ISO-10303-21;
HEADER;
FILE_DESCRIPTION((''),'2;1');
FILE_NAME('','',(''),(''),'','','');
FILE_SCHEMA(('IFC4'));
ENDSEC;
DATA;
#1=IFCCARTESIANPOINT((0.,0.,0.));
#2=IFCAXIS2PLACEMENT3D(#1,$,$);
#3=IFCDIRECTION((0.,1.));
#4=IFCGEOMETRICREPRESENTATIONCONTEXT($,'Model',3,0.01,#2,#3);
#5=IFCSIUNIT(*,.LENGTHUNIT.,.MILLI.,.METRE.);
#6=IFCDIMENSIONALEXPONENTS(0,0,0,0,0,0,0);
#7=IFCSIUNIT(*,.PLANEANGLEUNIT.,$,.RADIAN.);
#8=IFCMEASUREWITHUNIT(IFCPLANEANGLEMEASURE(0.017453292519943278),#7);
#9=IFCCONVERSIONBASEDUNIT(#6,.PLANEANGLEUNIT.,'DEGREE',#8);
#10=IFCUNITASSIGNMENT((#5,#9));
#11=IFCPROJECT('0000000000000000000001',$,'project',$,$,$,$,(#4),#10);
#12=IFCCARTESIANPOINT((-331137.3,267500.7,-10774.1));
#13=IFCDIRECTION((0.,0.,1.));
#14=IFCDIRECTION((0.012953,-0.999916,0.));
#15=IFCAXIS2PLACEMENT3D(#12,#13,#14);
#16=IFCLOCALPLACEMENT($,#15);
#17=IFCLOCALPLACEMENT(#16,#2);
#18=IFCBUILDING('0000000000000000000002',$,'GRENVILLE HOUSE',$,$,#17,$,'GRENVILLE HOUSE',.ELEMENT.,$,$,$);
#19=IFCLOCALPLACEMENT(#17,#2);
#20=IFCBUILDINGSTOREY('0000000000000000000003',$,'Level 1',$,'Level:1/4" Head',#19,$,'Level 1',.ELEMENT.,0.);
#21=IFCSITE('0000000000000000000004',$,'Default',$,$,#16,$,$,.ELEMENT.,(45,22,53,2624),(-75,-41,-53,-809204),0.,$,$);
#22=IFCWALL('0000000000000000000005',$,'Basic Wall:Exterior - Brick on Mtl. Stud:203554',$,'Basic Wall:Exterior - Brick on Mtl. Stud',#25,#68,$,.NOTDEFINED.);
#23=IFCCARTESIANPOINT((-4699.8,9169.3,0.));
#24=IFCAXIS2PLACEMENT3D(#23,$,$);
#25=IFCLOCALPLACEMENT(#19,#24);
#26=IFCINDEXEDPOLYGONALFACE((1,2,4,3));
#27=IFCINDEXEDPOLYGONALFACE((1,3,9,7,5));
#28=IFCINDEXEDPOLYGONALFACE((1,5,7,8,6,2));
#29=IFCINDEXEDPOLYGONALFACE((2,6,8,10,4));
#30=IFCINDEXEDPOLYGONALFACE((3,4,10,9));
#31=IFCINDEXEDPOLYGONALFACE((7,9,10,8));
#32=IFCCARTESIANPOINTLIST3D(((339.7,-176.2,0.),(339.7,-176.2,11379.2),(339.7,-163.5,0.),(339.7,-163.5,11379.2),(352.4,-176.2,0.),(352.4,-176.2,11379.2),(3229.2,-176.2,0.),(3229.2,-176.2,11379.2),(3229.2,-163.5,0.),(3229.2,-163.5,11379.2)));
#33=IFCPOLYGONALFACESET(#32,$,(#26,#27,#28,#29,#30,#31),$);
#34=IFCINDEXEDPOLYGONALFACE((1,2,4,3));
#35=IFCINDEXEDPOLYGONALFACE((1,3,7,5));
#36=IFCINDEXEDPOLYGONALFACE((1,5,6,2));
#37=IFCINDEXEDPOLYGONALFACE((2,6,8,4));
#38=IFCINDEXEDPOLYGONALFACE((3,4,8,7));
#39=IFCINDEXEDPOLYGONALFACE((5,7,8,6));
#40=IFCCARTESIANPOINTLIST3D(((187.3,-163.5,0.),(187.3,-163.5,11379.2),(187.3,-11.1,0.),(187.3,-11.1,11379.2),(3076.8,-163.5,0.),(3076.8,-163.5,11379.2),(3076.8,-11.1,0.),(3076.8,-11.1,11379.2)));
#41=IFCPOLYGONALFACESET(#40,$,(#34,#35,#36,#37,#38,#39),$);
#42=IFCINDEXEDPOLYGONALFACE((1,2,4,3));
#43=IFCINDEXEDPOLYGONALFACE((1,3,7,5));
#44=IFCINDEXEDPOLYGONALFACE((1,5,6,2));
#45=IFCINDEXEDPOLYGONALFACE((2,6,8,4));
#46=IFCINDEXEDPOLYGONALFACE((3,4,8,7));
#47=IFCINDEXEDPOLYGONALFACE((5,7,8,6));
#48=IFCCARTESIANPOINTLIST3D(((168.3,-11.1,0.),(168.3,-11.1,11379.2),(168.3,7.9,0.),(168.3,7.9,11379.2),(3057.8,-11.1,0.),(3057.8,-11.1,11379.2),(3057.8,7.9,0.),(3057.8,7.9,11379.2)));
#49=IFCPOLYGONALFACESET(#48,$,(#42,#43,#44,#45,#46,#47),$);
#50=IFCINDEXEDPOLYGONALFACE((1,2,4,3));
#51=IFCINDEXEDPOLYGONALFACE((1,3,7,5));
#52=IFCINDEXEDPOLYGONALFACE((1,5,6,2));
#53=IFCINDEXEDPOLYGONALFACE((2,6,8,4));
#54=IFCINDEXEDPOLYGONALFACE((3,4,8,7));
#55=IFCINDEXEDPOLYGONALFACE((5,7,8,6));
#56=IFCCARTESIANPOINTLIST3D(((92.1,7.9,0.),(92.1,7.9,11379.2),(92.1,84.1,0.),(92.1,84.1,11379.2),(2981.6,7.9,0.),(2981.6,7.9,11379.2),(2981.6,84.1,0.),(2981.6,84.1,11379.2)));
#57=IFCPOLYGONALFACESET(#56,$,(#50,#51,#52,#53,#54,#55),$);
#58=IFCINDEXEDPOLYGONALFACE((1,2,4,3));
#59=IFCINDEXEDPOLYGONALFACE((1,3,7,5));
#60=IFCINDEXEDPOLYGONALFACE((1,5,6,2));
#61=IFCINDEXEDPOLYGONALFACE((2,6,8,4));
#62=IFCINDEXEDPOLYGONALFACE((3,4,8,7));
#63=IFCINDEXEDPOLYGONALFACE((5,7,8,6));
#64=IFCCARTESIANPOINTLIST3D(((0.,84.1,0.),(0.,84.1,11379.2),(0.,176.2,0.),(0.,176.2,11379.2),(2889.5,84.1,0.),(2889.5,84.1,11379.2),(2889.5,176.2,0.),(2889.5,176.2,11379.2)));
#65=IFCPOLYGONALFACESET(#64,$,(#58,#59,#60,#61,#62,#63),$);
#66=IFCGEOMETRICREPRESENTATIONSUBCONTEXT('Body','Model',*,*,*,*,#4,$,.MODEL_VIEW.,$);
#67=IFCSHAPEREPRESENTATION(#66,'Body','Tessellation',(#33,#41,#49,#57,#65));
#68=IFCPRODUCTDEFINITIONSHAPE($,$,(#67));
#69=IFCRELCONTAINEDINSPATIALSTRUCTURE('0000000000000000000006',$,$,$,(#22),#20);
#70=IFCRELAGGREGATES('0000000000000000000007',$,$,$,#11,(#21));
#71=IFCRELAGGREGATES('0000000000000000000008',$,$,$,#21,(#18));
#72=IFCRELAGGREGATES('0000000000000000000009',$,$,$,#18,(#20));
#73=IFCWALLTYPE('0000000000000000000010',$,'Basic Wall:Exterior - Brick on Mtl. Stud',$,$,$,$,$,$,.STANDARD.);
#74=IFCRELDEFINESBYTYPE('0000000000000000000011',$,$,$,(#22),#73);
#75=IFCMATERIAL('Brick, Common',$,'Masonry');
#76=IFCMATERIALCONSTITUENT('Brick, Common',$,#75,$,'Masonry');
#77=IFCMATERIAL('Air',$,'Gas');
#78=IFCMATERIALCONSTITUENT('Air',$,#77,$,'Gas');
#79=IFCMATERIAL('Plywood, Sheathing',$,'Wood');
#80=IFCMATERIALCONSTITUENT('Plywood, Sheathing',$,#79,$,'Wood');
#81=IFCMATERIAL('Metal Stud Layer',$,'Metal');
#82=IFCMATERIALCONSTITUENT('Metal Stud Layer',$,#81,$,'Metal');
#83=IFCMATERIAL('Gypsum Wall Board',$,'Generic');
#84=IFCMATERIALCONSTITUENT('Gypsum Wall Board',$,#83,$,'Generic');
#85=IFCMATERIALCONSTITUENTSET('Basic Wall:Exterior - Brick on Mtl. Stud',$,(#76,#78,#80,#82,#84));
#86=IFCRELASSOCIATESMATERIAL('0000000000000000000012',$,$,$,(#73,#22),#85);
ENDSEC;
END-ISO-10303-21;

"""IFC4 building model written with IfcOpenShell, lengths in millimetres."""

from ifc_helpers import new_model, entity, si_unit, converted_unit, direction, frame, origin, place, context, subcontext, project, spatial, indexed_curve, outline, extrude, material, constituent, constituent_set, type_object, element, save


model = new_model("IFC4")

# Units and contexts
model_context = context("Model", 3, precision=0.01, world=origin(), true_north=direction((0.0, 1.0)))
body_context = subcontext(model_context, "Body", "Model", "MODEL_VIEW")
ifc_project = project(units=[si_unit("LENGTHUNIT", "METRE", prefix="MILLI"), converted_unit("PLANEANGLEUNIT", "DEGREE", entity("IfcPlaneAngleMeasure", 0.017453292519943278), si_unit("PLANEANGLEUNIT", "RADIAN"), dimensions=[0, 0, 0, 0, 0, 0, 0])], contexts=[model_context])

# Site, building, storey
site_placement = place(None, frame((-331137.3, 267500.7, -10774.1), z_axis=(0.0, 0.0, 1.0), x_axis=(0.012953, -0.999916, 0.0)))
site = spatial("IfcSite", under=ifc_project, at=site_placement, Name="Default", CompositionType="ELEMENT", RefLatitude=(45, 22, 53, 2624), RefLongitude=(-75, -41, -53, -809204), RefElevation=0.0)
building_placement = place(site_placement, origin())
building = spatial("IfcBuilding", under=site, at=building_placement, Name="GRENVILLE HOUSE", LongName="GRENVILLE HOUSE", CompositionType="ELEMENT")
storey_placement = place(building_placement, origin())
storey = spatial("IfcBuildingStorey", under=building, at=storey_placement, Name="Level 1", ObjectType="Level:1/4\" Head", LongName="Level 1", CompositionType="ELEMENT", Elevation=0.0)

# Wall
ifc_material_1 = material(Name="Brick, Common", Category="Masonry")
ifc_constituent_1 = constituent(ifc_material_1, Name="Brick, Common", Category="Masonry")
ifc_material_2 = material(Name="Air", Category="Gas")
ifc_constituent_2 = constituent(ifc_material_2, Name="Air", Category="Gas")
ifc_material_3 = material(Name="Plywood, Sheathing", Category="Wood")
ifc_constituent_3 = constituent(ifc_material_3, Name="Plywood, Sheathing", Category="Wood")
ifc_material_4 = material(Name="Metal Stud Layer", Category="Metal")
ifc_constituent_4 = constituent(ifc_material_4, Name="Metal Stud Layer", Category="Metal")
ifc_material_5 = material(Name="Gypsum Wall Board", Category="Generic")
ifc_constituent_5 = constituent(ifc_material_5, Name="Gypsum Wall Board", Category="Generic")
ifc_constituent_set_1 = constituent_set(constituents=[ifc_constituent_1, ifc_constituent_2, ifc_constituent_3, ifc_constituent_4, ifc_constituent_5], Name="Basic Wall:Exterior - Brick on Mtl. Stud")
wall_type_1 = type_object("IfcWallType", Name="Basic Wall:Exterior - Brick on Mtl. Stud", PredefinedType="STANDARD", material=ifc_constituent_set_1)
wall_1_placement = place(storey_placement, frame((-4699.8, 9169.3, 0.0)))
element("IfcWall", 1, at=wall_1_placement, inside=storey, type_object=wall_type_1, material=ifc_constituent_set_1, Name="Basic Wall:Exterior - Brick on Mtl. Stud:203554", ObjectType="Basic Wall:Exterior - Brick on Mtl. Stud", PredefinedType="NOTDEFINED", context=body_context, shape_type="SweptSolid", body=[
    extrude(outline(indexed_curve([(-1145.6, -5.1), (1731.2, -5.1), (1731.2, 7.6), (-1158.3, 7.6), (-1158.3, -5.1), (-1145.6, -5.1)], self_intersect=False)), frame((1498.1, -171.1, 0.0)), (0.0, 0.0, 1.0), 11379.2),
    extrude(outline(indexed_curve([(-1444.7, -76.2), (1444.7, -76.2), (1444.7, 76.2), (-1444.7, 76.2), (-1444.7, -76.2)], self_intersect=False)), frame((1632.1, -87.3, 0.0)), (0.0, 0.0, 1.0), 11379.2),
    extrude(outline(indexed_curve([(-1444.7, -9.5), (1444.7, -9.5), (1444.7, 9.5), (-1444.7, 9.5), (-1444.7, -9.5)], self_intersect=False)), frame((1613.0, -1.6, 0.0)), (0.0, 0.0, 1.0), 11379.2),
    extrude(outline(indexed_curve([(-1444.7, -38.1), (1444.7, -38.1), (1444.7, 38.1), (-1444.7, 38.1), (-1444.7, -38.1)], self_intersect=False)), frame((1536.8, 46.0, 0.0)), (0.0, 0.0, 1.0), 11379.2),
    extrude(outline(indexed_curve([(-46.0, -1444.7), (46.0, -1444.7), (46.0, 1444.7), (-46.0, 1444.7), (-46.0, -1444.7)], self_intersect=False)), frame((1444.7, 130.2, 0.0), z_axis=(0.0, 0.0, 1.0), x_axis=(0.0, -1.0, 0.0)), (0.0, 0.0, 1.0), 11379.2),
])

save(model, "model.ifc")
